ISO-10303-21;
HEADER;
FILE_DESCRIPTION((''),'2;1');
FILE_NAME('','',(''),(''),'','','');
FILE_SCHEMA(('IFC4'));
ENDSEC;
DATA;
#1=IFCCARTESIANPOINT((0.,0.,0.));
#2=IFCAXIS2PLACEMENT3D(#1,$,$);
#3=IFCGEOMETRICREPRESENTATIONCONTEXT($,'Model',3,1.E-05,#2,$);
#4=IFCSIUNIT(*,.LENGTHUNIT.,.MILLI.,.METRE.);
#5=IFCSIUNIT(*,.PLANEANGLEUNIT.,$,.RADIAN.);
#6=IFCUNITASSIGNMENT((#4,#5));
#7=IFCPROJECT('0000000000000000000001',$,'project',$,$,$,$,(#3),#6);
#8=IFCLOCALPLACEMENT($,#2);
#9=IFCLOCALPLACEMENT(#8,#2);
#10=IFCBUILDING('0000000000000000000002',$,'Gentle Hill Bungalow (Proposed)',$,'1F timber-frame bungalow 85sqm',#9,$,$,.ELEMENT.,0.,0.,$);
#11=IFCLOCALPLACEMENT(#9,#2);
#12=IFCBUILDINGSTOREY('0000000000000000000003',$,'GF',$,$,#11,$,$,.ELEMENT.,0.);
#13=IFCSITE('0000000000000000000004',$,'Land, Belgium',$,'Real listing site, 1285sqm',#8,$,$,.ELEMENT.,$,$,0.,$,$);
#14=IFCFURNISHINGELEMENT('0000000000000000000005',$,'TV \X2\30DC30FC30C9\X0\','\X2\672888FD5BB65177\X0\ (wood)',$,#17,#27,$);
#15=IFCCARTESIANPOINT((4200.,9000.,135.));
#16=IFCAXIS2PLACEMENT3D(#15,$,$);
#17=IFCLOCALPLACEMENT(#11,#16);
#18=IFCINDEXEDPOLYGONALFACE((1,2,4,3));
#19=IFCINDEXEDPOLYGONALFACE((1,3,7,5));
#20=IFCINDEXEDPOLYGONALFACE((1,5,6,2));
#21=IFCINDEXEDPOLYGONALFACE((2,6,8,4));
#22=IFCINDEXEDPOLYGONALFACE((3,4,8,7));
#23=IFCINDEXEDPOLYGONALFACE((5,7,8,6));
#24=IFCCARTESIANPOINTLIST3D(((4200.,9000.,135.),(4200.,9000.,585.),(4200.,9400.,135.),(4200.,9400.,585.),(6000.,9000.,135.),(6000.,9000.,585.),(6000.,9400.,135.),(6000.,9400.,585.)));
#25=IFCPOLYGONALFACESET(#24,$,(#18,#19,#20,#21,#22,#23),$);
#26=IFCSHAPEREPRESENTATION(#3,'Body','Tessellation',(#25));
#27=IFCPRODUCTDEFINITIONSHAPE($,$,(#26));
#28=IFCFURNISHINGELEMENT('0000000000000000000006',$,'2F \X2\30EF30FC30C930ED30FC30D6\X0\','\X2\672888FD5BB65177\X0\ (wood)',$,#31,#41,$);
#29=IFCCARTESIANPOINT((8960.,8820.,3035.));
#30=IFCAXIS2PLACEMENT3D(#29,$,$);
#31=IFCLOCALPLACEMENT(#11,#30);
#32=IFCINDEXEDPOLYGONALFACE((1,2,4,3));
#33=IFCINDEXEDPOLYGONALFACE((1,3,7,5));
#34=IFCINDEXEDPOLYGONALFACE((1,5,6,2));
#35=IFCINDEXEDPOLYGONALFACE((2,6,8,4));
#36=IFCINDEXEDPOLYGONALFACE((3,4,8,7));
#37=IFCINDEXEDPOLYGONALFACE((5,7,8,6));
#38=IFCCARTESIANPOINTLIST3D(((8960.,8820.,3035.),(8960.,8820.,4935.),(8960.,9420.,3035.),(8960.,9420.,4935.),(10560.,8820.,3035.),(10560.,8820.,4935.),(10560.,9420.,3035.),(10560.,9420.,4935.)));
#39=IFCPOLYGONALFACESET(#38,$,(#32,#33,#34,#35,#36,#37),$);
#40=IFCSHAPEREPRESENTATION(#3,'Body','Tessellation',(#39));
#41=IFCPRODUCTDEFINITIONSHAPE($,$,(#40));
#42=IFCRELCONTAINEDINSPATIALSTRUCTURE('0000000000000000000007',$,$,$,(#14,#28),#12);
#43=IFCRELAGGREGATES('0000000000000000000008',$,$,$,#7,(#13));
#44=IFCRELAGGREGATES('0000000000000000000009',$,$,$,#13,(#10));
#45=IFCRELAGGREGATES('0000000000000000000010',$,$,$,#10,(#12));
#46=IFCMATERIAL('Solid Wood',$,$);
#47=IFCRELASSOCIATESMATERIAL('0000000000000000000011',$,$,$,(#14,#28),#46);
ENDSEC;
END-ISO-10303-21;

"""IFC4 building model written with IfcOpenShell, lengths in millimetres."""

from ifc_helpers import new_model, si_unit, frame, frame_2d, origin, place, context, project, spatial, rectangle, extrude, material, element, save


model = new_model("IFC4")

# Units and contexts
model_context = context("Model", 3, precision=1e-05, world=origin())
ifc_project = project(units=[si_unit("LENGTHUNIT", "METRE", prefix="MILLI"), si_unit("PLANEANGLEUNIT", "RADIAN")], contexts=[model_context])

# Site, building, storey
site_placement = place(None, origin())
site = spatial("IfcSite", under=ifc_project, at=site_placement, Name="Land, Belgium", ObjectType="Real listing site, 1285sqm", CompositionType="ELEMENT", RefElevation=0.0)
building_placement = place(site_placement, origin())
building = spatial("IfcBuilding", under=site, at=building_placement, Name="Gentle Hill Bungalow (Proposed)", ObjectType="1F timber-frame bungalow 85sqm", CompositionType="ELEMENT", ElevationOfRefHeight=0.0, ElevationOfTerrain=0.0)
storey_placement = place(building_placement, origin())
storey = spatial("IfcBuildingStorey", under=building, at=storey_placement, Name="GF", CompositionType="ELEMENT", Elevation=0.0)

# Shared definitions
ifc_material_1 = material(Name="Solid Wood")

# Furnishing elements
furnishing_1_placement = place(storey_placement, frame((4200.0, 9000.0, 135.0)))
element("IfcFurnishingElement", 1, at=furnishing_1_placement, inside=storey, material=ifc_material_1, Name="TV ボード", Description="木製家具 (wood)", context=model_context, shape_type="SweptSolid", body=[
    extrude(rectangle(XDim=1800.0, YDim=400.0, at=frame_2d((900.0, 200.0))), frame((4200.0, 9000.0, 135.0)), (0.0, 0.0, 1.0), 450.0),
])
furnishing_2_placement = place(storey_placement, frame((8960.0, 8820.0, 3035.0)))
element("IfcFurnishingElement", 2, at=furnishing_2_placement, inside=storey, material=ifc_material_1, Name="2F ワードローブ", Description="木製家具 (wood)", context=model_context, shape_type="SweptSolid", body=[
    extrude(rectangle(XDim=1600.0, YDim=600.0, at=frame_2d((800.0, 300.0))), frame((8960.0, 8820.0, 3035.0)), (0.0, 0.0, 1.0), 1900.0),
])

save(model, "model.ifc")
